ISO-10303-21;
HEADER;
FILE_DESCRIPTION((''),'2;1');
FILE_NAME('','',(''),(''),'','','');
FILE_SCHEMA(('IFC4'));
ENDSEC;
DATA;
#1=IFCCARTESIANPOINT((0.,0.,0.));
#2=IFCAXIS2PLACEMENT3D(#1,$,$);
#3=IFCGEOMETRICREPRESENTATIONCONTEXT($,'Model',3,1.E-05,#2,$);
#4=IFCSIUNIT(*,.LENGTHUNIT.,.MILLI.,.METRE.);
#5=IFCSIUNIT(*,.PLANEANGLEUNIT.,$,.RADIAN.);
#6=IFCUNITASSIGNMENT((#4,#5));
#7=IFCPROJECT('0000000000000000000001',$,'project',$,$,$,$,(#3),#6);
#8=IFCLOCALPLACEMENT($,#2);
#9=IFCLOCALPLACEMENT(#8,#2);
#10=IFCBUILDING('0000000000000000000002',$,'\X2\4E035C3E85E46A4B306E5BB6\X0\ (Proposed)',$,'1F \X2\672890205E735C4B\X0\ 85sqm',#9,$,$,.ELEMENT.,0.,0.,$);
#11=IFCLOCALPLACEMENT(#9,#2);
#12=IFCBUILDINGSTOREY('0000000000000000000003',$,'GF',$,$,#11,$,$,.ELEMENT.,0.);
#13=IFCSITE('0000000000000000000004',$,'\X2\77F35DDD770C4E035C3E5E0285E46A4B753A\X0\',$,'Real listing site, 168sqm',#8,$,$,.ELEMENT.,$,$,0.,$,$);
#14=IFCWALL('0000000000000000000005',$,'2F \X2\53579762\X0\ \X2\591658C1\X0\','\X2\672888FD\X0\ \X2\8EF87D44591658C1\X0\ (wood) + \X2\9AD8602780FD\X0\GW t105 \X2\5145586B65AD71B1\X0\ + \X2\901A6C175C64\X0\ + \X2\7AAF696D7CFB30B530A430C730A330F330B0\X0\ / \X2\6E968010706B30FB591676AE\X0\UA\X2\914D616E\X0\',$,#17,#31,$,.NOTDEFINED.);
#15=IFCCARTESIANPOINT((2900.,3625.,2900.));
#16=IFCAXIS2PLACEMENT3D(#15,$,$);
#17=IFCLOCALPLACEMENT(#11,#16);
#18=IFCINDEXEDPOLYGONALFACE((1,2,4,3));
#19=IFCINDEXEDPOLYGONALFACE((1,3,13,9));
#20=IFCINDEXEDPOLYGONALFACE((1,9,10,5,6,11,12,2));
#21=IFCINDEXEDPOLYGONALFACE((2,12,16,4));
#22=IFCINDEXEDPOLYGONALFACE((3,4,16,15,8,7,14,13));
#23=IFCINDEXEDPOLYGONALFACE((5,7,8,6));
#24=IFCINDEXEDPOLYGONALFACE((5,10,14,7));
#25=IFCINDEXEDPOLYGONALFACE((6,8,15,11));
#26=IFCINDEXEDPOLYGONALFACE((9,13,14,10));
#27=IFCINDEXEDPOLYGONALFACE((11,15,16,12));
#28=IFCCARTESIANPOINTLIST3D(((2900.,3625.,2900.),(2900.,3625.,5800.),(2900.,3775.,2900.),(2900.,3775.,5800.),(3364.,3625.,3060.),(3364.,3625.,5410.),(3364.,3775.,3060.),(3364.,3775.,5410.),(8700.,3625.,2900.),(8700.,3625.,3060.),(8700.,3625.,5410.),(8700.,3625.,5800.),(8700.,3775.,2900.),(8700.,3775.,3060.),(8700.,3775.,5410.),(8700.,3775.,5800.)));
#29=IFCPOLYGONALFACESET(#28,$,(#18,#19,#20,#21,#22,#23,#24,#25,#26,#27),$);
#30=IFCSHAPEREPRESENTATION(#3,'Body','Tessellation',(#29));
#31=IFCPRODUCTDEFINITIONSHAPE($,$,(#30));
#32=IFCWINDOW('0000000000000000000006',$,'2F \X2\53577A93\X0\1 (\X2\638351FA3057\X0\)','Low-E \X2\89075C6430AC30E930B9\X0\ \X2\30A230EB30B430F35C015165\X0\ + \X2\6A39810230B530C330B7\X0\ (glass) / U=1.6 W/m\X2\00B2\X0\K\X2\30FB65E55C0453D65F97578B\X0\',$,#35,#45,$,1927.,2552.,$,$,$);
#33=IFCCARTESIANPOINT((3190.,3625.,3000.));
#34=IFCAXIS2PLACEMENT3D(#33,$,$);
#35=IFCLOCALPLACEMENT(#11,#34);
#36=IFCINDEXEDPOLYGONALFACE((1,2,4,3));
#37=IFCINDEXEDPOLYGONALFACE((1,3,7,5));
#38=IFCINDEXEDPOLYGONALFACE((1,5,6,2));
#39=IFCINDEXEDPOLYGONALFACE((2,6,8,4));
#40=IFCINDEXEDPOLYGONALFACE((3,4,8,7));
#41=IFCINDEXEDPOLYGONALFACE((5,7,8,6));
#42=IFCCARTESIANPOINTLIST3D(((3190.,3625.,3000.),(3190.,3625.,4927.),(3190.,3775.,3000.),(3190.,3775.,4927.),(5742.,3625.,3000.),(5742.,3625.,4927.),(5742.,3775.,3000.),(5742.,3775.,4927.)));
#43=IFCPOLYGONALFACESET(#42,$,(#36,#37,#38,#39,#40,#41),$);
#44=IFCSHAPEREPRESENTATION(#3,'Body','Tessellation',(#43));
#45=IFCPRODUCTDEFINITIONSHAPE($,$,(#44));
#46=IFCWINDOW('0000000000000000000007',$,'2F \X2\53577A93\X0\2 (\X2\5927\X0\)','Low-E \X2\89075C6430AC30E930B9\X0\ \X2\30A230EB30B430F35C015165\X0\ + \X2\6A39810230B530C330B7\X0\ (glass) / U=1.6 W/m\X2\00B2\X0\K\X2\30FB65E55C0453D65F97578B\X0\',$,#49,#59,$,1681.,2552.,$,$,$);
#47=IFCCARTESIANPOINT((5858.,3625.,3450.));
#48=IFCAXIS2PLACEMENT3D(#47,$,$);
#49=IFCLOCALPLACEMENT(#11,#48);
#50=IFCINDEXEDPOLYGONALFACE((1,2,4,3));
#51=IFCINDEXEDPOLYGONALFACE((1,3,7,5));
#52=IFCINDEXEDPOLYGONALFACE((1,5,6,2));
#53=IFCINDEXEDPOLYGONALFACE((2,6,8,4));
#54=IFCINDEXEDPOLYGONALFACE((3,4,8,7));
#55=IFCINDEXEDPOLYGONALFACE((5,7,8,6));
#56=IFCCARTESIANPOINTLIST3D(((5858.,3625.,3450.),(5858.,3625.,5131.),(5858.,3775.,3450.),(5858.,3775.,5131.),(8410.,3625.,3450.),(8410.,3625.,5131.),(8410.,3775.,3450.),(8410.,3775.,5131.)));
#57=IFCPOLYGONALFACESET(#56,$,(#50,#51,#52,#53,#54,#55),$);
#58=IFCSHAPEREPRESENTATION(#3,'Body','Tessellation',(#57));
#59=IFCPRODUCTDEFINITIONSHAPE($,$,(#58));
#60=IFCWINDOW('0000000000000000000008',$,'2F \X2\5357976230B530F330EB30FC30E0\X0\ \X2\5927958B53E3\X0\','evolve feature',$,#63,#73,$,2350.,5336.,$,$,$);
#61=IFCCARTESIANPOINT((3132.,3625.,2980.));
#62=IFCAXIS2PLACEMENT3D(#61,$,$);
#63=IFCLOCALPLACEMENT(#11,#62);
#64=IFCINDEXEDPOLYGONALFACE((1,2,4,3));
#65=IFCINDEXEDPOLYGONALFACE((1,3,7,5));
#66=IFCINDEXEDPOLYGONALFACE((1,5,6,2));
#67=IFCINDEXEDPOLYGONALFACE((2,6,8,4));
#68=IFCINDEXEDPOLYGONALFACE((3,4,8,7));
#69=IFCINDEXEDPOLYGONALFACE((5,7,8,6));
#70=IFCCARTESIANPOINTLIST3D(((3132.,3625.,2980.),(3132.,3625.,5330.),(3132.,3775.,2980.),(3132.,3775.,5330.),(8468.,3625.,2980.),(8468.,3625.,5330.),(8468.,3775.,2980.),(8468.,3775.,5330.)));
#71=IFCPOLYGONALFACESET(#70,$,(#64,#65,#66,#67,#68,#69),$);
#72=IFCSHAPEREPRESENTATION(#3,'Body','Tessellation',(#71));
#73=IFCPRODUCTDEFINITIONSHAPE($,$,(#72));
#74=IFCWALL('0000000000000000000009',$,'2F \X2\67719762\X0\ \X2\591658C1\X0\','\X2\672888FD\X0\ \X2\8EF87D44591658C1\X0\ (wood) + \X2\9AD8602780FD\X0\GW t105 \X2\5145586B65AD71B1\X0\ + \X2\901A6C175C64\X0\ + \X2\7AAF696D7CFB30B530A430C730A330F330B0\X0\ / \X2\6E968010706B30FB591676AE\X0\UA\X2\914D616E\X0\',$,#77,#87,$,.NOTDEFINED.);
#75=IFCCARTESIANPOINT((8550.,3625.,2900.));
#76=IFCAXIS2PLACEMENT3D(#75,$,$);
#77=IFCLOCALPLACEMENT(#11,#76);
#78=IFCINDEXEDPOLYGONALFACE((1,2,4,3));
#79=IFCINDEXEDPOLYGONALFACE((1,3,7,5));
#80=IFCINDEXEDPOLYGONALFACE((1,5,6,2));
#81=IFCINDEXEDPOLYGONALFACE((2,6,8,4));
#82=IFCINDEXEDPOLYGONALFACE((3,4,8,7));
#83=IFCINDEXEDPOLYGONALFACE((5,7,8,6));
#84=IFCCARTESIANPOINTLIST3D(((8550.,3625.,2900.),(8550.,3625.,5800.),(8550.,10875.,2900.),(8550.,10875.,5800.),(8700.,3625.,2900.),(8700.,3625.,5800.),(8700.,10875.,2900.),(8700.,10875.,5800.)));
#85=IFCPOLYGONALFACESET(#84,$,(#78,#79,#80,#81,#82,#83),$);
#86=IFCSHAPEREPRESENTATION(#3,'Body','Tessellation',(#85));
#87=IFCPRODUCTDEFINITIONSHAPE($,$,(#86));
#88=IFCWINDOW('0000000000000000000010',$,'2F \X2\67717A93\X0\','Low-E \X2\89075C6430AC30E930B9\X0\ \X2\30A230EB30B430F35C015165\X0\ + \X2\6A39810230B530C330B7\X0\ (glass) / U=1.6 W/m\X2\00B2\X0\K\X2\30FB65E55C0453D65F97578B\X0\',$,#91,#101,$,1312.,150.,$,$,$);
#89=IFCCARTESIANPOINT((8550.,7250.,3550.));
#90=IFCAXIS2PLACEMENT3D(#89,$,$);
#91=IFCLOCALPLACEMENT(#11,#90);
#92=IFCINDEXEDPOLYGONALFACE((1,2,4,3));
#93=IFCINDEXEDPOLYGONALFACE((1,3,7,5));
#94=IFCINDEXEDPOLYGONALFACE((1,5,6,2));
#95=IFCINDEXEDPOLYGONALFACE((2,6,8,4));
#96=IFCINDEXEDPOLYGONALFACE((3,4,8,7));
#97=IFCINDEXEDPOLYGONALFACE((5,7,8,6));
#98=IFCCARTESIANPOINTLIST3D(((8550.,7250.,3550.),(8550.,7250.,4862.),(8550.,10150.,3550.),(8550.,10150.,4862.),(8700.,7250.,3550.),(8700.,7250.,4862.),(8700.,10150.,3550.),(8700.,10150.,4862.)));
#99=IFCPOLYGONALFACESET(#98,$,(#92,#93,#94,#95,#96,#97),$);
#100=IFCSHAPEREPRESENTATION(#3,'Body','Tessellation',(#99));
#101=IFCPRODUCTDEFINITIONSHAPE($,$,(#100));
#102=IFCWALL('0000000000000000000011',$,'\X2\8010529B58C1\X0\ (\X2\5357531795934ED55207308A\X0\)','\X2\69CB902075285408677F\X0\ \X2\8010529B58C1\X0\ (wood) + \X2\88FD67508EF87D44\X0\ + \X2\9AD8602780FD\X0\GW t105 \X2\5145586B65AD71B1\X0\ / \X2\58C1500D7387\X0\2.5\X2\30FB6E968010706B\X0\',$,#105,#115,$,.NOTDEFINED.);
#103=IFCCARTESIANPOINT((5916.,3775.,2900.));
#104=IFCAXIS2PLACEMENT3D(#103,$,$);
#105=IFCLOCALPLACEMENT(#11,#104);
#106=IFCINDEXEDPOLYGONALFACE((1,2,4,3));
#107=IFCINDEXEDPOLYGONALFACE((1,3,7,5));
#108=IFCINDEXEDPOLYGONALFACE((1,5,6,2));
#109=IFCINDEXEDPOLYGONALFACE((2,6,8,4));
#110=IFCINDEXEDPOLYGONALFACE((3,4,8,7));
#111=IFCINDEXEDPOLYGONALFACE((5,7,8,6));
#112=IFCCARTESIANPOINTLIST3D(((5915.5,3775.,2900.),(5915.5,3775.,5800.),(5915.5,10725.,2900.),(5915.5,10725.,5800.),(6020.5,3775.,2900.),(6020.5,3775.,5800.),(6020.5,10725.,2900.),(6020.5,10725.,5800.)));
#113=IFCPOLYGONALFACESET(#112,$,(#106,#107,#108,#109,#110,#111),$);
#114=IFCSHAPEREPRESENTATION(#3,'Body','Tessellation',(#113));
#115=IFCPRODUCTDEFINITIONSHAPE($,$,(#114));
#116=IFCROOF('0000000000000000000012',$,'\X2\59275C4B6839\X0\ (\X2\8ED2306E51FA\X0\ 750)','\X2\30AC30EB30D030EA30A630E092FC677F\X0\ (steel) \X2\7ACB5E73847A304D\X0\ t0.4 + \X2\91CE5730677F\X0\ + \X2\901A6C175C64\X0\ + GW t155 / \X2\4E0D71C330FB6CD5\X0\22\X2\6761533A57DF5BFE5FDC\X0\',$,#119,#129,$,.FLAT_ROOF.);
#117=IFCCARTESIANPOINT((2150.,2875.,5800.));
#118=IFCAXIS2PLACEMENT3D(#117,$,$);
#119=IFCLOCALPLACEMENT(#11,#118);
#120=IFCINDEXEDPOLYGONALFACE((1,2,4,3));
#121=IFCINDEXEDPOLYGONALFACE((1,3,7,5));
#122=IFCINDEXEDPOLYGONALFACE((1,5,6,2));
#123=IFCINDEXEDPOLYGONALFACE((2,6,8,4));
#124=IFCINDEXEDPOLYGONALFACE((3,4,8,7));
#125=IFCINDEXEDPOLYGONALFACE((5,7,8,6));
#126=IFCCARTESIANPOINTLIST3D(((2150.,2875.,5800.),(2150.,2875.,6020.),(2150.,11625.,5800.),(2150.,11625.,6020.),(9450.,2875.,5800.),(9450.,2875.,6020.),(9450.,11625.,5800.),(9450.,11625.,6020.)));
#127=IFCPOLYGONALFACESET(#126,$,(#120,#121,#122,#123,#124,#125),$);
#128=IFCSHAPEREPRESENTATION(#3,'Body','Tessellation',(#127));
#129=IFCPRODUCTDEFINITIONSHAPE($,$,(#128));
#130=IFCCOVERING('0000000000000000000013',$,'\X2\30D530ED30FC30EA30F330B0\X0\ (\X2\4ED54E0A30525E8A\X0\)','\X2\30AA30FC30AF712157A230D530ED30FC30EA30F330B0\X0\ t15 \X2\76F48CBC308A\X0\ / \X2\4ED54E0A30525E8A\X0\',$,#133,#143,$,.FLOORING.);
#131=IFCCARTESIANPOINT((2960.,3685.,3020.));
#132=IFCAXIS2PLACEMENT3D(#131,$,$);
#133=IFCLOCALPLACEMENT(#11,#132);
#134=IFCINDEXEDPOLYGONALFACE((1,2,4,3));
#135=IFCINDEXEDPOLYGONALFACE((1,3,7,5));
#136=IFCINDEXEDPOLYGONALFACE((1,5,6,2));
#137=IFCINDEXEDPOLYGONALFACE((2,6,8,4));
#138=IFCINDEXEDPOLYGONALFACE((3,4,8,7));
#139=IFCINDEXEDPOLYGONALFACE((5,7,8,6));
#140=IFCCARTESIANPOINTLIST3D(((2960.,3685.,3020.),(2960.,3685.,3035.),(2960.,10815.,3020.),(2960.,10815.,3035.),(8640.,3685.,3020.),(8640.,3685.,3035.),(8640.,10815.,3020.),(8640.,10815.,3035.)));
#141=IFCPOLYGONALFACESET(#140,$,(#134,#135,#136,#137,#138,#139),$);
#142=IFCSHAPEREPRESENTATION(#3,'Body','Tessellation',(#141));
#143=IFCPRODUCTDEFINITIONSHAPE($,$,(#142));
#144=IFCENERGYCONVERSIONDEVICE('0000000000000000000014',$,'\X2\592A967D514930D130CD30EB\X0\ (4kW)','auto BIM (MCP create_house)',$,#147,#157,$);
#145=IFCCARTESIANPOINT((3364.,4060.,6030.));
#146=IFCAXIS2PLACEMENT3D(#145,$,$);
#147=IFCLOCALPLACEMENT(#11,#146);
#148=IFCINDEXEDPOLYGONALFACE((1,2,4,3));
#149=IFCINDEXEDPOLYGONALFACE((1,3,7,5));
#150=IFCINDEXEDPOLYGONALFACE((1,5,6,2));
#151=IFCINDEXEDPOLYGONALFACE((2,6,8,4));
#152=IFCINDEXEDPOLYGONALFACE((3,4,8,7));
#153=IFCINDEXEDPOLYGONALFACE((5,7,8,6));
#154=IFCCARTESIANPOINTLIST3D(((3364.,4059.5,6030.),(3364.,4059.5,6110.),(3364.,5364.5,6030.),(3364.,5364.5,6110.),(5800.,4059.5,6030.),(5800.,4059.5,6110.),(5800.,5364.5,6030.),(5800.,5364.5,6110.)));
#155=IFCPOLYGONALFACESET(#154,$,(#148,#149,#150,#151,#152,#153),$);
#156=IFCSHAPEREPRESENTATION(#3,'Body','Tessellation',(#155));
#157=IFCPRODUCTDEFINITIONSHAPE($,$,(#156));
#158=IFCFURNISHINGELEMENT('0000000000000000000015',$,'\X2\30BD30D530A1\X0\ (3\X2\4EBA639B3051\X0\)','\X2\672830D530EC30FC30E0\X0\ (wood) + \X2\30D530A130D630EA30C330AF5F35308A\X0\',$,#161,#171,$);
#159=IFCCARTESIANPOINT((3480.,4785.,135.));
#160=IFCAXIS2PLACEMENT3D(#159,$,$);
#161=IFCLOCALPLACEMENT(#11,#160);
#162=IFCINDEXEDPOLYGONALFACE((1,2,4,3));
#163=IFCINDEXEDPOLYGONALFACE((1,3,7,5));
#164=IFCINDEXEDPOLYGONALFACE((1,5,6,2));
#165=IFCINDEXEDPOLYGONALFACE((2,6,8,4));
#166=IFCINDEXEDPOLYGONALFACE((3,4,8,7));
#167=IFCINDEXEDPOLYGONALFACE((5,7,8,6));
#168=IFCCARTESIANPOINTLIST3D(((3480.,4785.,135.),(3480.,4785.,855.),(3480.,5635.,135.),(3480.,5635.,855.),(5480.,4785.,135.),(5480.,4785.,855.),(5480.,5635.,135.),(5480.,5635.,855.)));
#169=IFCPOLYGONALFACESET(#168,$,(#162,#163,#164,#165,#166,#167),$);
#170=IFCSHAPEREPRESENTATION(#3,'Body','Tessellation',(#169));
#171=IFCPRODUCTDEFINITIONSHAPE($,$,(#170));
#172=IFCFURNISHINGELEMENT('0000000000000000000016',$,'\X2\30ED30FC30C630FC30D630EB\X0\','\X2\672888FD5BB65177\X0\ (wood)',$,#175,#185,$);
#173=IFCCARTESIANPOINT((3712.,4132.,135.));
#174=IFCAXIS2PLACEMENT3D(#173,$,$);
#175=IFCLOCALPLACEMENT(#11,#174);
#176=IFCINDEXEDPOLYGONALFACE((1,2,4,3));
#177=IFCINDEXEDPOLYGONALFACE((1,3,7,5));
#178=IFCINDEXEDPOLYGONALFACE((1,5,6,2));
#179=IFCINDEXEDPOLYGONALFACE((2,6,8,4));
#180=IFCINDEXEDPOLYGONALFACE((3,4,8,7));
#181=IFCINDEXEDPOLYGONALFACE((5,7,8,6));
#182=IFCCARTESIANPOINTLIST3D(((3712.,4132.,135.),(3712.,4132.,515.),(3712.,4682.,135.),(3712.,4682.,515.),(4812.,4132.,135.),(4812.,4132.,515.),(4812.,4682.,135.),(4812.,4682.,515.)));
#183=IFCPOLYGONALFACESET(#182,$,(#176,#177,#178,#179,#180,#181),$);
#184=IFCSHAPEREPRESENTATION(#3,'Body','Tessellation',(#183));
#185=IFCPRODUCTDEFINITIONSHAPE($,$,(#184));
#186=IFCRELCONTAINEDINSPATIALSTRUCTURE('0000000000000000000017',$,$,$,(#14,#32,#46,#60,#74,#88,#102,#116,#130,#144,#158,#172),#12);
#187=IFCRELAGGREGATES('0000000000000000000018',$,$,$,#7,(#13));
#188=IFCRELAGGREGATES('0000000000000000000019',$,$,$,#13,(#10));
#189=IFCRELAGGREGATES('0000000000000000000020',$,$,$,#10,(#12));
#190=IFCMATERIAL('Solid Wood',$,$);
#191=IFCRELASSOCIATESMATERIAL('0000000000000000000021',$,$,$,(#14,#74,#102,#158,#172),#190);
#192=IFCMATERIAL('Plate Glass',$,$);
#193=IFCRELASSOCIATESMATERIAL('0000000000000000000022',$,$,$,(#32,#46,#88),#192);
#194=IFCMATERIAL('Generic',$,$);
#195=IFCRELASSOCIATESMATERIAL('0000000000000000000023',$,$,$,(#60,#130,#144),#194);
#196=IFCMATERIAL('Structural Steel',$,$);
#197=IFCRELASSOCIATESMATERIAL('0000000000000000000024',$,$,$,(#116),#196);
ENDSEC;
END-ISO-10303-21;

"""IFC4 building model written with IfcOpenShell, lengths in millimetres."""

from ifc_helpers import new_model, si_unit, frame, frame_2d, origin, place, context, project, spatial, rectangle, extrude, material, element, fill, save


model = new_model("IFC4")

# Units and contexts
model_context = context("Model", 3, precision=1e-05, world=origin())
ifc_project = project(units=[si_unit("LENGTHUNIT", "METRE", prefix="MILLI"), si_unit("PLANEANGLEUNIT", "RADIAN")], contexts=[model_context])

# Site, building, storey
site_placement = place(None, origin())
site = spatial("IfcSite", under=ifc_project, at=site_placement, Name="石川県七尾市藤橋町", ObjectType="Real listing site, 168sqm", CompositionType="ELEMENT", RefElevation=0.0)
building_placement = place(site_placement, origin())
building = spatial("IfcBuilding", under=site, at=building_placement, Name="七尾藤橋の家 (Proposed)", ObjectType="1F 木造平屋 85sqm", CompositionType="ELEMENT", ElevationOfRefHeight=0.0, ElevationOfTerrain=0.0)
storey_placement = place(building_placement, origin())
storey = spatial("IfcBuildingStorey", under=building, at=storey_placement, Name="GF", CompositionType="ELEMENT", Elevation=0.0)

# Shared definitions
ifc_material_1 = material(Name="Solid Wood")

# Wall, openings, windows
wall_1_placement = place(storey_placement, frame((2900.0, 3625.0, 2900.0)))
wall_1 = element("IfcWall", 1, at=wall_1_placement, inside=storey, material=ifc_material_1, Name="2F 南面 外壁", Description="木製 軸組外壁 (wood) + 高性能GW t105 充填断熱 + 通気層 + 窯業系サイディング / 準耐火・外皮UA配慮", PredefinedType="NOTDEFINED", context=model_context, shape_type="SweptSolid", body=[
    extrude(rectangle(XDim=5800.0, YDim=150.0, at=frame_2d((2900.0, 75.0))), frame((2900.0, 3625.0, 2900.0)), (0.0, 0.0, 1.0), 2900.0),
])
opening_1_placement = place(storey_placement, frame((3190.0, 3625.0, 3000.0)))
opening_1 = element("IfcOpeningElement", 2, at=opening_1_placement, cuts=wall_1, PredefinedType="NOTDEFINED", context=model_context, shape_type="SweptSolid", body=[
    extrude(rectangle(XDim=2552.0, YDim=150.0, at=frame_2d((1276.0, 75.0))), frame((3190.0, 3625.0, 3000.0)), (0.0, 0.0, 1.0), 1927.0),
])
opening_2_placement = place(storey_placement, frame((5858.0, 3625.0, 3450.0)))
opening_2 = element("IfcOpeningElement", 3, at=opening_2_placement, cuts=wall_1, PredefinedType="NOTDEFINED", context=model_context, shape_type="SweptSolid", body=[
    extrude(rectangle(XDim=2552.0, YDim=150.0, at=frame_2d((1276.0, 75.0))), frame((5858.0, 3625.0, 3450.0)), (0.0, 0.0, 1.0), 1681.0),
])
opening_3_placement = place(storey_placement, frame((3132.0, 3625.0, 2980.0)))
opening_3 = element("IfcOpeningElement", 4, at=opening_3_placement, cuts=wall_1, PredefinedType="NOTDEFINED", context=model_context, shape_type="SweptSolid", body=[
    extrude(rectangle(XDim=5336.0, YDim=150.0, at=frame_2d((2668.0, 75.0))), frame((3132.0, 3625.0, 2980.0)), (0.0, 0.0, 1.0), 2350.0),
])
ifc_material_2 = material(Name="Plate Glass")
window_1_placement = place(storey_placement, frame((3190.0, 3625.0, 3000.0)))
window_1 = element("IfcWindow", 5, at=window_1_placement, inside=storey, material=ifc_material_2, Name="2F 南窓1 (掃出し)", Description="Low-E 複層ガラス アルゴン封入 + 樹脂サッシ (glass) / U=1.6 W/m²K・日射取得型", OverallHeight=1927.0, OverallWidth=2552.0, context=model_context, shape_type="SweptSolid", body=[
    extrude(rectangle(XDim=2552.0, YDim=150.0, at=frame_2d((1276.0, 75.0))), frame((3190.0, 3625.0, 3000.0)), (0.0, 0.0, 1.0), 1927.0),
])
fill(opening_1, window_1)
window_2_placement = place(storey_placement, frame((5858.0, 3625.0, 3450.0)))
window_2 = element("IfcWindow", 6, at=window_2_placement, inside=storey, material=ifc_material_2, Name="2F 南窓2 (大)", Description="Low-E 複層ガラス アルゴン封入 + 樹脂サッシ (glass) / U=1.6 W/m²K・日射取得型", OverallHeight=1681.0, OverallWidth=2552.0, context=model_context, shape_type="SweptSolid", body=[
    extrude(rectangle(XDim=2552.0, YDim=150.0, at=frame_2d((1276.0, 75.0))), frame((5858.0, 3625.0, 3450.0)), (0.0, 0.0, 1.0), 1681.0),
])
fill(opening_2, window_2)
ifc_material_3 = material(Name="Generic")
window_3_placement = place(storey_placement, frame((3132.0, 3625.0, 2980.0)))
window_3 = element("IfcWindow", 7, at=window_3_placement, inside=storey, material=ifc_material_3, Name="2F 南面サンルーム 大開口", Description="evolve feature", OverallHeight=2350.0, OverallWidth=5336.0, context=model_context, shape_type="SweptSolid", body=[
    extrude(rectangle(XDim=5336.0, YDim=150.0, at=frame_2d((2668.0, 75.0))), frame((3132.0, 3625.0, 2980.0)), (0.0, 0.0, 1.0), 2350.0),
])
fill(opening_3, window_3)

# Wall, opening, window
wall_2_placement = place(storey_placement, frame((8550.0, 3625.0, 2900.0)))
wall_2 = element("IfcWall", 8, at=wall_2_placement, inside=storey, material=ifc_material_1, Name="2F 東面 外壁", Description="木製 軸組外壁 (wood) + 高性能GW t105 充填断熱 + 通気層 + 窯業系サイディング / 準耐火・外皮UA配慮", PredefinedType="NOTDEFINED", context=model_context, shape_type="SweptSolid", body=[
    extrude(rectangle(XDim=150.0, YDim=7250.0, at=frame_2d((75.0, 3625.0))), frame((8550.0, 3625.0, 2900.0)), (0.0, 0.0, 1.0), 2900.0),
])
opening_4_placement = place(storey_placement, frame((8550.0, 7250.0, 3550.0)))
opening_4 = element("IfcOpeningElement", 9, at=opening_4_placement, cuts=wall_2, PredefinedType="NOTDEFINED", context=model_context, shape_type="SweptSolid", body=[
    extrude(rectangle(XDim=150.0, YDim=2900.0, at=frame_2d((75.0, 1450.0))), frame((8550.0, 7250.0, 3550.0)), (0.0, 0.0, 1.0), 1312.0),
])
window_4_placement = place(storey_placement, frame((8550.0, 7250.0, 3550.0)))
window_4 = element("IfcWindow", 10, at=window_4_placement, inside=storey, material=ifc_material_2, Name="2F 東窓", Description="Low-E 複層ガラス アルゴン封入 + 樹脂サッシ (glass) / U=1.6 W/m²K・日射取得型", OverallHeight=1312.0, OverallWidth=150.0, context=model_context, shape_type="SweptSolid", body=[
    extrude(rectangle(XDim=150.0, YDim=2900.0, at=frame_2d((75.0, 1450.0))), frame((8550.0, 7250.0, 3550.0)), (0.0, 0.0, 1.0), 1312.0),
])
fill(opening_4, window_4)

# Wall
wall_3_placement = place(storey_placement, frame((5916.0, 3775.0, 2900.0)))
element("IfcWall", 11, at=wall_3_placement, inside=storey, material=ifc_material_1, Name="耐力壁 (南北間仕切り)", Description="構造用合板 耐力壁 (wood) + 製材軸組 + 高性能GW t105 充填断熱 / 壁倍率2.5・準耐火", PredefinedType="NOTDEFINED", context=model_context, shape_type="SweptSolid", body=[
    extrude(rectangle(XDim=105.0, YDim=6950.0, at=frame_2d((52.0, 3475.0))), frame((5916.0, 3775.0, 2900.0)), (0.0, 0.0, 1.0), 2900.0),
])

# Roof
ifc_material_4 = material(Name="Structural Steel")
roof_placement = place(storey_placement, frame((2150.0, 2875.0, 5800.0)))
element("IfcRoof", 12, at=roof_placement, inside=storey, material=ifc_material_4, Name="大屋根 (軒の出 750)", Description="ガルバリウム鋼板 (steel) 立平葺き t0.4 + 野地板 + 通気層 + GW t155 / 不燃・法22条区域対応", PredefinedType="FLAT_ROOF", context=model_context, shape_type="SweptSolid", body=[
    extrude(rectangle(XDim=7300.0, YDim=8750.0, at=frame_2d((3650.0, 4375.0))), frame((2150.0, 2875.0, 5800.0)), (0.0, 0.0, 1.0), 220.0),
])

# Covering
covering_placement = place(storey_placement, frame((2960.0, 3685.0, 3020.0)))
element("IfcCovering", 13, at=covering_placement, inside=storey, material=ifc_material_3, Name="フローリング (仕上げ床)", Description="オーク無垢フローリング t15 直貼り / 仕上げ床", PredefinedType="FLOORING", context=model_context, shape_type="SweptSolid", body=[
    extrude(rectangle(XDim=5680.0, YDim=7130.0, at=frame_2d((2840.0, 3565.0))), frame((2960.0, 3685.0, 3020.0)), (0.0, 0.0, 1.0), 15.0),
])

# Energy conversion device
energy_conversion_device_placement = place(storey_placement, frame((3364.0, 4060.0, 6030.0)))
element("IfcEnergyConversionDevice", 14, at=energy_conversion_device_placement, inside=storey, material=ifc_material_3, Name="太陽光パネル (4kW)", Description="auto BIM (MCP create_house)", context=model_context, shape_type="SweptSolid", body=[
    extrude(rectangle(XDim=2436.0, YDim=1305.0, at=frame_2d((1218.0, 652.0))), frame((3364.0, 4060.0, 6030.0)), (0.0, 0.0, 1.0), 80.0),
])

# Furnishing elements
furnishing_1_placement = place(storey_placement, frame((3480.0, 4785.0, 135.0)))
element("IfcFurnishingElement", 15, at=furnishing_1_placement, inside=storey, material=ifc_material_1, Name="ソファ (3人掛け)", Description="木フレーム (wood) + ファブリック張り", context=model_context, shape_type="SweptSolid", body=[
    extrude(rectangle(XDim=2000.0, YDim=850.0, at=frame_2d((1000.0, 425.0))), frame((3480.0, 4785.0, 135.0)), (0.0, 0.0, 1.0), 720.0),
])
furnishing_2_placement = place(storey_placement, frame((3712.0, 4132.0, 135.0)))
element("IfcFurnishingElement", 16, at=furnishing_2_placement, inside=storey, material=ifc_material_1, Name="ローテーブル", Description="木製家具 (wood)", context=model_context, shape_type="SweptSolid", body=[
    extrude(rectangle(XDim=1100.0, YDim=550.0, at=frame_2d((550.0, 275.0))), frame((3712.0, 4132.0, 135.0)), (0.0, 0.0, 1.0), 380.0),
])

save(model, "model.ifc")
